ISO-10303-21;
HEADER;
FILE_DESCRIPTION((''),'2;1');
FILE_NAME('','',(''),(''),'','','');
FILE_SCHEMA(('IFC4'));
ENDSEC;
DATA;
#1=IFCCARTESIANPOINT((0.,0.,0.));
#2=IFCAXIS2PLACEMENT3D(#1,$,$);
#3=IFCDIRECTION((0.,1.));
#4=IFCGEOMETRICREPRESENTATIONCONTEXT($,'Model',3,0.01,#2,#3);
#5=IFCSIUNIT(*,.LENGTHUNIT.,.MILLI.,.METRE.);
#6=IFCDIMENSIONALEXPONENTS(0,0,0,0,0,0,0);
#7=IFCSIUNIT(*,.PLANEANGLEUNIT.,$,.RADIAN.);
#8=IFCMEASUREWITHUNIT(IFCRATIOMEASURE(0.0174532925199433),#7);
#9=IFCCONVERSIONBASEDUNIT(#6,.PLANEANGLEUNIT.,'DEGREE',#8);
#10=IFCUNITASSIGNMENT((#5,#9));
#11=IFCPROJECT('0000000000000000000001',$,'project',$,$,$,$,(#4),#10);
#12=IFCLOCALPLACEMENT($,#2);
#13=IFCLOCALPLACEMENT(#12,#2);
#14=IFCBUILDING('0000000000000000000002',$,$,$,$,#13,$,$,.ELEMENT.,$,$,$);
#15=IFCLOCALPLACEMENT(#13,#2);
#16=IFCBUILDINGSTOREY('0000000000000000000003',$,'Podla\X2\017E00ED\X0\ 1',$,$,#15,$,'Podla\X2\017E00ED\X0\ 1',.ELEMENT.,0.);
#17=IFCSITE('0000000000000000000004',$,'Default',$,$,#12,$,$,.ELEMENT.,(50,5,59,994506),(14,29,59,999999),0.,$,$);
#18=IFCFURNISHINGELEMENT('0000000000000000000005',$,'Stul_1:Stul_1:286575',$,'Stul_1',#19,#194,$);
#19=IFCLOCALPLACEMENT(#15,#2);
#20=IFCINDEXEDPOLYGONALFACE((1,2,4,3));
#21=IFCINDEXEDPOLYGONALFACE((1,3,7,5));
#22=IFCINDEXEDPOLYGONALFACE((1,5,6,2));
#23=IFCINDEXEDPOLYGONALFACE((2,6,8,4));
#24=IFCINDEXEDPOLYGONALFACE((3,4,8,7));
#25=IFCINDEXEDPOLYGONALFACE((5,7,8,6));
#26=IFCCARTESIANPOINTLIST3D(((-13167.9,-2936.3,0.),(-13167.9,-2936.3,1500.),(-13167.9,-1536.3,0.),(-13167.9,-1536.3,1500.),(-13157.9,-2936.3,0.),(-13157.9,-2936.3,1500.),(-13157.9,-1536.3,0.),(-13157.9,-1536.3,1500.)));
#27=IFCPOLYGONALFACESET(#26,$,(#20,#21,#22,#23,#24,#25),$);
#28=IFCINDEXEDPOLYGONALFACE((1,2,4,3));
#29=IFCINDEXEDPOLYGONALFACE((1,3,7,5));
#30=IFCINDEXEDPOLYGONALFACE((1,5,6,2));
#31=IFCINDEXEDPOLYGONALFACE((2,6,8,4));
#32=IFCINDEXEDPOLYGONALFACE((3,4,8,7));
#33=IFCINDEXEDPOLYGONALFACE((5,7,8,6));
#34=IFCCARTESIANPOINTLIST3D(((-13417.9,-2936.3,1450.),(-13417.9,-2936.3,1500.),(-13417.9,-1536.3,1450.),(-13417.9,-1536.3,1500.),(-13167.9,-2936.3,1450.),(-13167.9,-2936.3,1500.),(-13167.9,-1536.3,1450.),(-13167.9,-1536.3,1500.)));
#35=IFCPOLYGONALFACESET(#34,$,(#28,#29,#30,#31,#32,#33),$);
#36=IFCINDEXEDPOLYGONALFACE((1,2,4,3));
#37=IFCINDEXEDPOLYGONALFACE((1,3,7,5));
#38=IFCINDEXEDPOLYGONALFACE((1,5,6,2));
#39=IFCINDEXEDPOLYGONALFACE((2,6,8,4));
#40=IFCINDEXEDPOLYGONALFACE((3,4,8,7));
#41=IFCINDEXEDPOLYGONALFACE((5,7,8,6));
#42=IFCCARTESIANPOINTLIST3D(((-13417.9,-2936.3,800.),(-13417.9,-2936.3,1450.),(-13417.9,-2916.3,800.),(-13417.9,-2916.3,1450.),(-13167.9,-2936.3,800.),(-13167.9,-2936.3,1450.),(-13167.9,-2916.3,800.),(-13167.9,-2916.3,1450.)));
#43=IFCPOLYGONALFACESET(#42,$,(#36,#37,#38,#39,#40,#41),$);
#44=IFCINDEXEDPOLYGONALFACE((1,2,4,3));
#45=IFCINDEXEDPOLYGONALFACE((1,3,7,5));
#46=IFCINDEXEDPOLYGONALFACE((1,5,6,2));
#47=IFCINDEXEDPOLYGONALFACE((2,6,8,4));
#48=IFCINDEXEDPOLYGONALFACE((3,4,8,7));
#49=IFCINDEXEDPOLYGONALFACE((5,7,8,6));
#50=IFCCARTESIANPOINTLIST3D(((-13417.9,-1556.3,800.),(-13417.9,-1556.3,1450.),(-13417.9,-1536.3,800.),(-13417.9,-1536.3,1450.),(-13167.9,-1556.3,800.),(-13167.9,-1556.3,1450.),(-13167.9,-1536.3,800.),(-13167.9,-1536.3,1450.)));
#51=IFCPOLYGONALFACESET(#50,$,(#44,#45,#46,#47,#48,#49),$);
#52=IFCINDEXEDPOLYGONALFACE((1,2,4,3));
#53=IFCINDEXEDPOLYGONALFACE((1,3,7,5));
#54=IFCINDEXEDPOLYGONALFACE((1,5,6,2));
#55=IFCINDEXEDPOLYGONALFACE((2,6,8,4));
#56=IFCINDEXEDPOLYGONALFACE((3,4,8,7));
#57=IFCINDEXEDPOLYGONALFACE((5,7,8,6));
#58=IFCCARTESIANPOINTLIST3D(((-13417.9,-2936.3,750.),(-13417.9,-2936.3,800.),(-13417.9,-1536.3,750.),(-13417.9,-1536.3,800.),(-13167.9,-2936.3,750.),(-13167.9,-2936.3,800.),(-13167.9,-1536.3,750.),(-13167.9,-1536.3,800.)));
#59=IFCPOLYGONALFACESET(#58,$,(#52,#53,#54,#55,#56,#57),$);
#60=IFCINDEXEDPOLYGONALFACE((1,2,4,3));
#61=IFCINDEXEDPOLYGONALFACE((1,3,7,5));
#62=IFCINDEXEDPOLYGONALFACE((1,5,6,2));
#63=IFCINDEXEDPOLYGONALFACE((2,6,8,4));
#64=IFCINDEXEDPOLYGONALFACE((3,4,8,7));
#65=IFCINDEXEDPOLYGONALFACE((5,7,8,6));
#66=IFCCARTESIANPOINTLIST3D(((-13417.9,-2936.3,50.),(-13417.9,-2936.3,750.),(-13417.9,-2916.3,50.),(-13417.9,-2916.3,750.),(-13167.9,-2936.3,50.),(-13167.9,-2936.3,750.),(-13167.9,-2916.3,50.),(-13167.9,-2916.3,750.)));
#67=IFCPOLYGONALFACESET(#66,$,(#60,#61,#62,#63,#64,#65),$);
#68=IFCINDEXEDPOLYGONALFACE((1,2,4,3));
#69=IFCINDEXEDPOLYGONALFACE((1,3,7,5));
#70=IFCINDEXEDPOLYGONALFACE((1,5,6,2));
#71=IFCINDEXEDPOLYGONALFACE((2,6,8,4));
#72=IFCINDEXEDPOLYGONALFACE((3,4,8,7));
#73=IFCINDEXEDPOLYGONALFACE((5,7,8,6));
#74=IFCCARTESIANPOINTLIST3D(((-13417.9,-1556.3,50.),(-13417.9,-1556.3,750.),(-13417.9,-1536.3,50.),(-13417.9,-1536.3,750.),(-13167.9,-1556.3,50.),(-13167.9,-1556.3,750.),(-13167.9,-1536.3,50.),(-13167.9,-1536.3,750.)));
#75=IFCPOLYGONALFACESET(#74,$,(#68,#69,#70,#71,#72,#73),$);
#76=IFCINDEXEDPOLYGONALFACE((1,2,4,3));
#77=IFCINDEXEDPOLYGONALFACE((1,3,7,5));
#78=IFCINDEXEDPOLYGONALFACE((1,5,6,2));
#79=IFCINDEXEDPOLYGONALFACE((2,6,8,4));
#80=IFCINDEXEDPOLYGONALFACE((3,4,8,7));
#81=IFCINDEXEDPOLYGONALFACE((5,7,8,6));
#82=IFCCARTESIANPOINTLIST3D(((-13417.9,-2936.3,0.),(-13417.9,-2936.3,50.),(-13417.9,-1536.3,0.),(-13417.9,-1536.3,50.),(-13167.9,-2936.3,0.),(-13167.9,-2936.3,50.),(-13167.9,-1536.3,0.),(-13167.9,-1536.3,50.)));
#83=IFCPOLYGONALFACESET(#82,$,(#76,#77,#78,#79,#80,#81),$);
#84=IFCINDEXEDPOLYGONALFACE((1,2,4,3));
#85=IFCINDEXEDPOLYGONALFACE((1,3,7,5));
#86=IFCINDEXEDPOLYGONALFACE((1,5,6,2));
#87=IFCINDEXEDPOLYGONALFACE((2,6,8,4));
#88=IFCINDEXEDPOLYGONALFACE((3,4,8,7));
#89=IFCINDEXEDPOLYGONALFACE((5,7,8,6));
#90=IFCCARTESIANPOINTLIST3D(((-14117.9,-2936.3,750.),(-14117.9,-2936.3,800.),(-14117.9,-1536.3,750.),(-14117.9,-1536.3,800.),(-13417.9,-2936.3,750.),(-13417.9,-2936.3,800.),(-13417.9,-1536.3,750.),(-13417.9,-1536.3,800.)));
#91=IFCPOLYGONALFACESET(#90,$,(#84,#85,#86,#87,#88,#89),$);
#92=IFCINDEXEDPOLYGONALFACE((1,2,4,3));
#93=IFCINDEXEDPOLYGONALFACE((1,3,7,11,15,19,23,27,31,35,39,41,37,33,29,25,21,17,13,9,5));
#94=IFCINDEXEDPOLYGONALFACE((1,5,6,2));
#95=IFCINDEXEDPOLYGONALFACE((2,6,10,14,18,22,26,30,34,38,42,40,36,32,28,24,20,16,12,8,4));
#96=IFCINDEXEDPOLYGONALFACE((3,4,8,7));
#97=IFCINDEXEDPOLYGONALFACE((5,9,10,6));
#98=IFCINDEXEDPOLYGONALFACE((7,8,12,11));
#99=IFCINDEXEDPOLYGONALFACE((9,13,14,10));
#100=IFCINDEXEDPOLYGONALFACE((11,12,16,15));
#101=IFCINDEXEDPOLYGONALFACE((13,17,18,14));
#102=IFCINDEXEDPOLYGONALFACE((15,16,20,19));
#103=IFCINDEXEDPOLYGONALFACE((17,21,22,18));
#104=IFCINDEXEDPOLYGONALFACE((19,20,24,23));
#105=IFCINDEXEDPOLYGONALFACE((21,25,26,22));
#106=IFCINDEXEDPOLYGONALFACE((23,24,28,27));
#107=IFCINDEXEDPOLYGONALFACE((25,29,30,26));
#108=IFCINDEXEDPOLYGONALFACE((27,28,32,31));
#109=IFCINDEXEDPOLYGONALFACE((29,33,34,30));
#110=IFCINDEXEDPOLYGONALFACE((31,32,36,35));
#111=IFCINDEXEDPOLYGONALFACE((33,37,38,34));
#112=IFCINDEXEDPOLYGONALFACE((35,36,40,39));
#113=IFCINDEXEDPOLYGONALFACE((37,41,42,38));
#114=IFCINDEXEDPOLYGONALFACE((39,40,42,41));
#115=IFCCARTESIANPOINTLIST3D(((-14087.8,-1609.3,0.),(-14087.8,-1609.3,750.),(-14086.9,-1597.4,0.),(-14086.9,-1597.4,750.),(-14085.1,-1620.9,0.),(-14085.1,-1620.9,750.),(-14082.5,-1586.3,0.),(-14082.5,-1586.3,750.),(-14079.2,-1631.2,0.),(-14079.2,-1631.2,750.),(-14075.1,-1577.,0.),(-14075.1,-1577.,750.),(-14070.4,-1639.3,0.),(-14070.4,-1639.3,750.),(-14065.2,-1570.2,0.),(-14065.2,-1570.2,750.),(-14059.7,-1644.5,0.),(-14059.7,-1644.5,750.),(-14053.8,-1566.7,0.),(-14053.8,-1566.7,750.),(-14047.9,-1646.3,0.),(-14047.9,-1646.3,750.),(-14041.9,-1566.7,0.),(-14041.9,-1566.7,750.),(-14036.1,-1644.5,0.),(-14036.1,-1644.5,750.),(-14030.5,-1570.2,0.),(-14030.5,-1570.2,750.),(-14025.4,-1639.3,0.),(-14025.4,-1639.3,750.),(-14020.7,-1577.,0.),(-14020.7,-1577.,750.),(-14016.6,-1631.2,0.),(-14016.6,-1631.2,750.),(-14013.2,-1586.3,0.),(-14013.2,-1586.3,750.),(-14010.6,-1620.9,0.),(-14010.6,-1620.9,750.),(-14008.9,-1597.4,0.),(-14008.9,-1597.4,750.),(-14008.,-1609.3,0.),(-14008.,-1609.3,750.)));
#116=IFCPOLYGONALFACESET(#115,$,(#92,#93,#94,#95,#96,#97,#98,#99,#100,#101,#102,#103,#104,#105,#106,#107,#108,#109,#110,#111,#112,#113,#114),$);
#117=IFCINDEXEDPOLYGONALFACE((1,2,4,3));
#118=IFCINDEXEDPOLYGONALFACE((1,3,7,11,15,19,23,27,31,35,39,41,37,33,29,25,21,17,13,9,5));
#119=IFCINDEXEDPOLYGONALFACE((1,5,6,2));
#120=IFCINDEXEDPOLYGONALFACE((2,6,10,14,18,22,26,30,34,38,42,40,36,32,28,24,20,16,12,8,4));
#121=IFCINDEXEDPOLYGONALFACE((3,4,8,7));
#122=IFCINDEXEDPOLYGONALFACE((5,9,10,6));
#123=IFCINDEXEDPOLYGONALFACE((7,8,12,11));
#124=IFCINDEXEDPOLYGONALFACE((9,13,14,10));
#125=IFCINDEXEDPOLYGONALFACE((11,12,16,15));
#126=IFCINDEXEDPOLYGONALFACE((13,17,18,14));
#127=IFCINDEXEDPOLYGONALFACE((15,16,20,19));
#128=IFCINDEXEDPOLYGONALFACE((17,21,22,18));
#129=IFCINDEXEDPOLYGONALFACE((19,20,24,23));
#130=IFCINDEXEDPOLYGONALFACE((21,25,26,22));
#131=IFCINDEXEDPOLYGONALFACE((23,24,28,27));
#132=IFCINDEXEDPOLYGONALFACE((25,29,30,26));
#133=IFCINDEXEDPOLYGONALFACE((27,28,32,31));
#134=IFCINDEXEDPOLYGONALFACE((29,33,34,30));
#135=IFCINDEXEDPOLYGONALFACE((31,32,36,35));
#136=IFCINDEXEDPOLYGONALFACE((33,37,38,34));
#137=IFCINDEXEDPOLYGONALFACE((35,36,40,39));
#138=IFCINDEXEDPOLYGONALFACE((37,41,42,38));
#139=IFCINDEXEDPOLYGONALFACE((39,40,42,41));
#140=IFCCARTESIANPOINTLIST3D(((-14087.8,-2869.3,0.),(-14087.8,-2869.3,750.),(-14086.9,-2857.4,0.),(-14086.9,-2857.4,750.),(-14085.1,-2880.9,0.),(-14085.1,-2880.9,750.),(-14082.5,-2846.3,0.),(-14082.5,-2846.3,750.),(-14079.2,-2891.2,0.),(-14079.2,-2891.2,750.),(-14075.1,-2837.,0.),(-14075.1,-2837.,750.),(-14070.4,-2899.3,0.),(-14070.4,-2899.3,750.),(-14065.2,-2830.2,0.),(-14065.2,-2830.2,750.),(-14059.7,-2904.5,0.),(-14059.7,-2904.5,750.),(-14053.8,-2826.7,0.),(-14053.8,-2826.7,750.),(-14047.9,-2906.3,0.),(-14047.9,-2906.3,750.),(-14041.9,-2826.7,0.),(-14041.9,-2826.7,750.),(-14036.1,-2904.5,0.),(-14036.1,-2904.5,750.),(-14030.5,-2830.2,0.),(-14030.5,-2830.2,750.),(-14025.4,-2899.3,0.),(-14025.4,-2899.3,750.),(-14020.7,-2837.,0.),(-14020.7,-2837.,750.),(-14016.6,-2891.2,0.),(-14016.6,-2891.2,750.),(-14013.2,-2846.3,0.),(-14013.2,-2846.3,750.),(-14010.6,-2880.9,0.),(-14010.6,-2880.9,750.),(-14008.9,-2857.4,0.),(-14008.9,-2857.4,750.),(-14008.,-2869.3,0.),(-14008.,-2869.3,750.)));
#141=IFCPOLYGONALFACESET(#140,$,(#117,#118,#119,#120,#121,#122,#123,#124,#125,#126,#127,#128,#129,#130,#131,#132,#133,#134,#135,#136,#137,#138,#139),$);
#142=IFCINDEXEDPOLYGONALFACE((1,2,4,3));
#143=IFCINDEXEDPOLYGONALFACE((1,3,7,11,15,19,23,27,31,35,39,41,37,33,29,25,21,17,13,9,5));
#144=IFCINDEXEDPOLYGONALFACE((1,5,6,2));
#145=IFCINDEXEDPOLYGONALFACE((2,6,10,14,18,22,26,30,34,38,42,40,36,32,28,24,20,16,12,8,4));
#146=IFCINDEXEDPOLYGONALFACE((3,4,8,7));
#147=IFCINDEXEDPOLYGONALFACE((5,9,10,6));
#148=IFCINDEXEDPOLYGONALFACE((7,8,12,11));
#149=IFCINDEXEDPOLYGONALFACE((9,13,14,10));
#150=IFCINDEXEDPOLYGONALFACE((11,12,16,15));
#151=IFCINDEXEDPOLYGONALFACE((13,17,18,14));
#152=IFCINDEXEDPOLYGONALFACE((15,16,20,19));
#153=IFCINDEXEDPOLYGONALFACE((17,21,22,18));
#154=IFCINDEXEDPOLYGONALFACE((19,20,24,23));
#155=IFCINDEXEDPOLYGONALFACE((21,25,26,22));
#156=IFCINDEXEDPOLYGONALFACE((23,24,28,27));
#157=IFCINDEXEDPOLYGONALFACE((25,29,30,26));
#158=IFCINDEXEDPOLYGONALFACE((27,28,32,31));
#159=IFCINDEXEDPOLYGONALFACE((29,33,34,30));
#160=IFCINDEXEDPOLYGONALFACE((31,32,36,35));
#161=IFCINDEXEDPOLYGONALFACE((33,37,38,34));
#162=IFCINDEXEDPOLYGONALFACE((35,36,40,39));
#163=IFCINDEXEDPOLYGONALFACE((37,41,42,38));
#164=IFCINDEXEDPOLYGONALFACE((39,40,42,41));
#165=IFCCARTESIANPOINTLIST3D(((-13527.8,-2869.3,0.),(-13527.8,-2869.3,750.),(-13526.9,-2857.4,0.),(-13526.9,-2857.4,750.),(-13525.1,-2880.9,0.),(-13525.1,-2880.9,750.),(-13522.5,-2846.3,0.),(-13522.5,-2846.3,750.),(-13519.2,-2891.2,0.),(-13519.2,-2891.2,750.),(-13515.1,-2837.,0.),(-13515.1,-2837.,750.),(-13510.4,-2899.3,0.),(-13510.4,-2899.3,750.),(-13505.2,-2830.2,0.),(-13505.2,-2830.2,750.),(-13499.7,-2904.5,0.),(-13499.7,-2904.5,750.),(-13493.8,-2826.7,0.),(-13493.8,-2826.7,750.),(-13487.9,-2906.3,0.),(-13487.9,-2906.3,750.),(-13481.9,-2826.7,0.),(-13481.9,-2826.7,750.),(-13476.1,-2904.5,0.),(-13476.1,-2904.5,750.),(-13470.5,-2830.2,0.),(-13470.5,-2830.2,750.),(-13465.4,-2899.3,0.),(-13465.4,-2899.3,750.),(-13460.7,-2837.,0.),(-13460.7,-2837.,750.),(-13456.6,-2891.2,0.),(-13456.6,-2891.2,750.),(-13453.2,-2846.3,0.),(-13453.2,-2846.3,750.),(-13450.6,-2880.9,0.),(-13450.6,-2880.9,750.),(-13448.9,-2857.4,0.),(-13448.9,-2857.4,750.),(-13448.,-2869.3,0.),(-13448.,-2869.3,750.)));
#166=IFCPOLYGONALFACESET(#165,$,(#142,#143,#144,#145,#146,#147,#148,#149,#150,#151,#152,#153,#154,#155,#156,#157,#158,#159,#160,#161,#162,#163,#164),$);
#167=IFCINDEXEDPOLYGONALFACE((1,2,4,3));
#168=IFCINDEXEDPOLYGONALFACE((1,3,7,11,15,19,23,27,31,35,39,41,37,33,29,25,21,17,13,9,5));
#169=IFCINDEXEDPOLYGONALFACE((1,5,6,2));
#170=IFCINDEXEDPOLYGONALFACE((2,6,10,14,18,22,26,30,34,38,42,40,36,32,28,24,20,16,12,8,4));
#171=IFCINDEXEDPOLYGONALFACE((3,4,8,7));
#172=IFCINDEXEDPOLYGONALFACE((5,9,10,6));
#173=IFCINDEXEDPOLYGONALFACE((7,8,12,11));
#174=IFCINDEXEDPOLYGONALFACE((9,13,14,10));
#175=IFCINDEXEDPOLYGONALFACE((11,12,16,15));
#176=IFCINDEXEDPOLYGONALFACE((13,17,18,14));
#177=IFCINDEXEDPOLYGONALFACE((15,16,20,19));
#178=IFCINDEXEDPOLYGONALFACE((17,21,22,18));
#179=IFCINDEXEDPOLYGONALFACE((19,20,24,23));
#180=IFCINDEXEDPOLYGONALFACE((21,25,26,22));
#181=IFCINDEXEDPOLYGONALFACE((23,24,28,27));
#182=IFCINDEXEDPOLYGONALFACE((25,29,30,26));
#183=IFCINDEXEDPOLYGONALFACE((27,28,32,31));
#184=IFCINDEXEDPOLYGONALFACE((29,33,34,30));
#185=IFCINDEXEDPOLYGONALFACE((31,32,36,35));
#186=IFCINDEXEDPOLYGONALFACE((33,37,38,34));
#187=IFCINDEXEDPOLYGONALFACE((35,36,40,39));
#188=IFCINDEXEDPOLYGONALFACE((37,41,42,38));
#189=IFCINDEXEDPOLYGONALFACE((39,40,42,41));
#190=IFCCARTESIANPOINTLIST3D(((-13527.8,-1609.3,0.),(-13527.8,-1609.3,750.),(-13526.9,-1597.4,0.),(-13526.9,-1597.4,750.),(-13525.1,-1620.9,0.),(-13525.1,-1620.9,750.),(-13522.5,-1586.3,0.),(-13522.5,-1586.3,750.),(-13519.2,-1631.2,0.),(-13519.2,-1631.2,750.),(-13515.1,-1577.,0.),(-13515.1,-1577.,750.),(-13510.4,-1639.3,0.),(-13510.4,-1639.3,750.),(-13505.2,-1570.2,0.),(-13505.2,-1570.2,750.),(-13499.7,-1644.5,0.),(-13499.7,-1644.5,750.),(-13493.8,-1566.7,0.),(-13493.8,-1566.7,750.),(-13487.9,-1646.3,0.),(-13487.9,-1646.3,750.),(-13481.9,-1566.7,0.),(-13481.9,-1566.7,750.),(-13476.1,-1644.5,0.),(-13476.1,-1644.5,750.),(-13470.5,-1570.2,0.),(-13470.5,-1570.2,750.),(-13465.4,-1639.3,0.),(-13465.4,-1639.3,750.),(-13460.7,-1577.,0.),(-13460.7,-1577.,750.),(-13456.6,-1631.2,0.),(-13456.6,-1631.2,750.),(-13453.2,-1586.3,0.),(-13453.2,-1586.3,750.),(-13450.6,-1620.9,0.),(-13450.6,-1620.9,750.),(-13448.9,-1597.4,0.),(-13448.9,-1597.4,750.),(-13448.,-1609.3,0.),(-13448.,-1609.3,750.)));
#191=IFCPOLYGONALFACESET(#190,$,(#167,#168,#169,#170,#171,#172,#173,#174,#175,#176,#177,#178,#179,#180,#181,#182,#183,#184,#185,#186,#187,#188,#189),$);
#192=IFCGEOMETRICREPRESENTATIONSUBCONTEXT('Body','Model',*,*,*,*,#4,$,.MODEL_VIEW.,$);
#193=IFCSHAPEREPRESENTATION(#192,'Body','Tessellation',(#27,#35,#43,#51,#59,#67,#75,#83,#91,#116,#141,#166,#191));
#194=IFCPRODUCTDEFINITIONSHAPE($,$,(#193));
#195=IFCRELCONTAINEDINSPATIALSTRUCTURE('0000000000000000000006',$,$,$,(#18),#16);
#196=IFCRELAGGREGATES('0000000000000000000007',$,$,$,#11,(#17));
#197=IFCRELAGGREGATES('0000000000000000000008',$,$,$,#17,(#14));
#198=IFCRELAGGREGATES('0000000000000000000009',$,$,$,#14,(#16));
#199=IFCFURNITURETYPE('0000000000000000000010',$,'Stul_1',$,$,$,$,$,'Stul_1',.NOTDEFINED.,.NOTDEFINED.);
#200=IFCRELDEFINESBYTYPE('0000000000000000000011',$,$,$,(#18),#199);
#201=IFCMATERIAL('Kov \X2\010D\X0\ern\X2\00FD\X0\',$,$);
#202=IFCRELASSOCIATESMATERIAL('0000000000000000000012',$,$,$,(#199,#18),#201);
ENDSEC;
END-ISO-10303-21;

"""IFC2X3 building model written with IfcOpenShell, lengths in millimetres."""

from ifc_helpers import new_model, entity, si_unit, converted_unit, direction, frame, frame_2d, origin, origin_2d_with_axis, place, context, subcontext, project, spatial, rectangle, circle, extrude, source, transform, mapped, material, type_object, type_shapes, element, save


model = new_model("IFC2X3")

# Units and contexts
model_context = context("Model", 3, precision=0.01, world=origin(), true_north=direction((0.0, 1.0)))
body_context = subcontext(model_context, "Body", "Model", "MODEL_VIEW")
ifc_project = project(units=[si_unit("LENGTHUNIT", "METRE", prefix="MILLI"), converted_unit("PLANEANGLEUNIT", "DEGREE", entity("IfcRatioMeasure", 0.0174532925199433), si_unit("PLANEANGLEUNIT", "RADIAN"), dimensions=[0, 0, 0, 0, 0, 0, 0])], contexts=[model_context])

# Site, building, storey
site_placement = place(None, origin())
site = spatial("IfcSite", under=ifc_project, at=site_placement, Name="Default", CompositionType="ELEMENT", RefLatitude=(50, 5, 59, 994506), RefLongitude=(14, 29, 59, 999999), RefElevation=0.0)
building_placement = place(site_placement, origin())
building = spatial("IfcBuilding", under=site, at=building_placement, CompositionType="ELEMENT")
storey_placement = place(building_placement, origin())
storey = spatial("IfcBuildingStorey", under=building, at=storey_placement, Name="Podlaží 1", LongName="Podlaží 1", CompositionType="ELEMENT", Elevation=0.0)

# Furnishing element
ifc_material_1 = material(Name="Kov černý")
furniture_type = type_object("IfcFurnitureType", Name="Stul_1", ElementType="Stul_1", material=ifc_material_1)
shared_shape_1 = source(origin(), body_context, "Body", "SweptSolid", [
    extrude(rectangle(XDim=1400.0, YDim=10.0, at=origin_2d_with_axis()), frame((0.0, 605.0, 0.0), z_axis=(0.0, 0.0, 1.0), x_axis=(-1.0, 0.0, 0.0)), (0.0, 0.0, 1.0), 1500.0),
    extrude(rectangle(XDim=1400.0, YDim=250.0, at=frame_2d((0.0, 0.0), x_axis=(1.0, 0.0))), frame((0.0, 475.0, 1450.0), z_axis=(0.0, 0.0, 1.0), x_axis=(-1.0, 0.0, 0.0)), (0.0, 0.0, 1.0), 50.0),
    extrude(rectangle(XDim=20.0, YDim=250.0, at=origin_2d_with_axis()), frame((690.0, 475.0, 800.0), z_axis=(0.0, 0.0, 1.0), x_axis=(-1.0, 0.0, 0.0)), (0.0, 0.0, 1.0), 650.0),
    extrude(rectangle(XDim=20.0, YDim=250.0, at=frame_2d((0.0, 0.0), x_axis=(1.0, 0.0))), frame((-690.0, 475.0, 800.0), z_axis=(0.0, 0.0, 1.0), x_axis=(-1.0, 0.0, 0.0)), (0.0, 0.0, 1.0), 650.0),
    extrude(rectangle(XDim=1400.0, YDim=250.0, at=origin_2d_with_axis()), frame((0.0, 475.0, 750.0), z_axis=(0.0, 0.0, 1.0), x_axis=(-1.0, 0.0, 0.0)), (0.0, 0.0, 1.0), 50.0),
    extrude(rectangle(XDim=20.0, YDim=250.0, at=origin_2d_with_axis()), frame((690.0, 475.0, 50.0), z_axis=(0.0, 0.0, 1.0), x_axis=(-1.0, 0.0, 0.0)), (0.0, 0.0, 1.0), 700.0),
    extrude(rectangle(XDim=20.0, YDim=250.0, at=frame_2d((0.0, 0.0), x_axis=(1.0, 0.0))), frame((-690.0, 475.0, 50.0), z_axis=(0.0, 0.0, 1.0), x_axis=(-1.0, 0.0, 0.0)), (0.0, 0.0, 1.0), 700.0),
    extrude(rectangle(XDim=1400.0, YDim=250.0, at=origin_2d_with_axis()), frame((0.0, 475.0, 0.0), z_axis=(0.0, 0.0, 1.0), x_axis=(-1.0, 0.0, 0.0)), (0.0, 0.0, 1.0), 50.0),
    extrude(rectangle(XDim=1400.0, YDim=700.0, at=origin_2d_with_axis()), frame((0.0, 0.0, 750.0), z_axis=(0.0, 0.0, 1.0), x_axis=(-1.0, 0.0, 0.0)), (0.0, 0.0, 1.0), 50.0),
    extrude(circle(Radius=40.0, at=frame_2d((0.0, 0.0), x_axis=(1.0, 0.0))), frame((-630.0, -280.0, 0.0)), (0.0, 0.0, 1.0), 750.0),
    extrude(circle(Radius=40.0, at=frame_2d((0.0, 0.0), x_axis=(1.0, 0.0))), frame((630.0, -280.0, 0.0)), (0.0, 0.0, 1.0), 750.0),
    extrude(circle(Radius=40.0, at=frame_2d((0.0, 0.0), x_axis=(1.0, 0.0))), frame((630.0, 280.0, 0.0)), (0.0, 0.0, 1.0), 750.0),
    extrude(circle(Radius=40.0, at=frame_2d((0.0, 0.0), x_axis=(1.0, 0.0))), frame((-630.0, 280.0, 0.0)), (0.0, 0.0, 1.0), 750.0),
])
type_shapes(furniture_type, [shared_shape_1])
for number, where, z_axis, x_axis, name in (
    (1, (-13767.9, -2236.3, 0.0), (0.0, 0.0, 1.0), (0.0, -1.0, 0.0), "Stul_1:Stul_1:286575"),
):
    element("IfcFurnishingElement", number, at=place(storey_placement, frame(where, z_axis=z_axis, x_axis=x_axis)), inside=storey, type_object=furniture_type, material=ifc_material_1, Name=name, ObjectType="Stul_1", context=body_context, shape_type="MappedRepresentation", body=[
        mapped(shared_shape_1, transform((0.0, 0.0, 0.0), scale=1.0)),
    ])

save(model, "model.ifc")
